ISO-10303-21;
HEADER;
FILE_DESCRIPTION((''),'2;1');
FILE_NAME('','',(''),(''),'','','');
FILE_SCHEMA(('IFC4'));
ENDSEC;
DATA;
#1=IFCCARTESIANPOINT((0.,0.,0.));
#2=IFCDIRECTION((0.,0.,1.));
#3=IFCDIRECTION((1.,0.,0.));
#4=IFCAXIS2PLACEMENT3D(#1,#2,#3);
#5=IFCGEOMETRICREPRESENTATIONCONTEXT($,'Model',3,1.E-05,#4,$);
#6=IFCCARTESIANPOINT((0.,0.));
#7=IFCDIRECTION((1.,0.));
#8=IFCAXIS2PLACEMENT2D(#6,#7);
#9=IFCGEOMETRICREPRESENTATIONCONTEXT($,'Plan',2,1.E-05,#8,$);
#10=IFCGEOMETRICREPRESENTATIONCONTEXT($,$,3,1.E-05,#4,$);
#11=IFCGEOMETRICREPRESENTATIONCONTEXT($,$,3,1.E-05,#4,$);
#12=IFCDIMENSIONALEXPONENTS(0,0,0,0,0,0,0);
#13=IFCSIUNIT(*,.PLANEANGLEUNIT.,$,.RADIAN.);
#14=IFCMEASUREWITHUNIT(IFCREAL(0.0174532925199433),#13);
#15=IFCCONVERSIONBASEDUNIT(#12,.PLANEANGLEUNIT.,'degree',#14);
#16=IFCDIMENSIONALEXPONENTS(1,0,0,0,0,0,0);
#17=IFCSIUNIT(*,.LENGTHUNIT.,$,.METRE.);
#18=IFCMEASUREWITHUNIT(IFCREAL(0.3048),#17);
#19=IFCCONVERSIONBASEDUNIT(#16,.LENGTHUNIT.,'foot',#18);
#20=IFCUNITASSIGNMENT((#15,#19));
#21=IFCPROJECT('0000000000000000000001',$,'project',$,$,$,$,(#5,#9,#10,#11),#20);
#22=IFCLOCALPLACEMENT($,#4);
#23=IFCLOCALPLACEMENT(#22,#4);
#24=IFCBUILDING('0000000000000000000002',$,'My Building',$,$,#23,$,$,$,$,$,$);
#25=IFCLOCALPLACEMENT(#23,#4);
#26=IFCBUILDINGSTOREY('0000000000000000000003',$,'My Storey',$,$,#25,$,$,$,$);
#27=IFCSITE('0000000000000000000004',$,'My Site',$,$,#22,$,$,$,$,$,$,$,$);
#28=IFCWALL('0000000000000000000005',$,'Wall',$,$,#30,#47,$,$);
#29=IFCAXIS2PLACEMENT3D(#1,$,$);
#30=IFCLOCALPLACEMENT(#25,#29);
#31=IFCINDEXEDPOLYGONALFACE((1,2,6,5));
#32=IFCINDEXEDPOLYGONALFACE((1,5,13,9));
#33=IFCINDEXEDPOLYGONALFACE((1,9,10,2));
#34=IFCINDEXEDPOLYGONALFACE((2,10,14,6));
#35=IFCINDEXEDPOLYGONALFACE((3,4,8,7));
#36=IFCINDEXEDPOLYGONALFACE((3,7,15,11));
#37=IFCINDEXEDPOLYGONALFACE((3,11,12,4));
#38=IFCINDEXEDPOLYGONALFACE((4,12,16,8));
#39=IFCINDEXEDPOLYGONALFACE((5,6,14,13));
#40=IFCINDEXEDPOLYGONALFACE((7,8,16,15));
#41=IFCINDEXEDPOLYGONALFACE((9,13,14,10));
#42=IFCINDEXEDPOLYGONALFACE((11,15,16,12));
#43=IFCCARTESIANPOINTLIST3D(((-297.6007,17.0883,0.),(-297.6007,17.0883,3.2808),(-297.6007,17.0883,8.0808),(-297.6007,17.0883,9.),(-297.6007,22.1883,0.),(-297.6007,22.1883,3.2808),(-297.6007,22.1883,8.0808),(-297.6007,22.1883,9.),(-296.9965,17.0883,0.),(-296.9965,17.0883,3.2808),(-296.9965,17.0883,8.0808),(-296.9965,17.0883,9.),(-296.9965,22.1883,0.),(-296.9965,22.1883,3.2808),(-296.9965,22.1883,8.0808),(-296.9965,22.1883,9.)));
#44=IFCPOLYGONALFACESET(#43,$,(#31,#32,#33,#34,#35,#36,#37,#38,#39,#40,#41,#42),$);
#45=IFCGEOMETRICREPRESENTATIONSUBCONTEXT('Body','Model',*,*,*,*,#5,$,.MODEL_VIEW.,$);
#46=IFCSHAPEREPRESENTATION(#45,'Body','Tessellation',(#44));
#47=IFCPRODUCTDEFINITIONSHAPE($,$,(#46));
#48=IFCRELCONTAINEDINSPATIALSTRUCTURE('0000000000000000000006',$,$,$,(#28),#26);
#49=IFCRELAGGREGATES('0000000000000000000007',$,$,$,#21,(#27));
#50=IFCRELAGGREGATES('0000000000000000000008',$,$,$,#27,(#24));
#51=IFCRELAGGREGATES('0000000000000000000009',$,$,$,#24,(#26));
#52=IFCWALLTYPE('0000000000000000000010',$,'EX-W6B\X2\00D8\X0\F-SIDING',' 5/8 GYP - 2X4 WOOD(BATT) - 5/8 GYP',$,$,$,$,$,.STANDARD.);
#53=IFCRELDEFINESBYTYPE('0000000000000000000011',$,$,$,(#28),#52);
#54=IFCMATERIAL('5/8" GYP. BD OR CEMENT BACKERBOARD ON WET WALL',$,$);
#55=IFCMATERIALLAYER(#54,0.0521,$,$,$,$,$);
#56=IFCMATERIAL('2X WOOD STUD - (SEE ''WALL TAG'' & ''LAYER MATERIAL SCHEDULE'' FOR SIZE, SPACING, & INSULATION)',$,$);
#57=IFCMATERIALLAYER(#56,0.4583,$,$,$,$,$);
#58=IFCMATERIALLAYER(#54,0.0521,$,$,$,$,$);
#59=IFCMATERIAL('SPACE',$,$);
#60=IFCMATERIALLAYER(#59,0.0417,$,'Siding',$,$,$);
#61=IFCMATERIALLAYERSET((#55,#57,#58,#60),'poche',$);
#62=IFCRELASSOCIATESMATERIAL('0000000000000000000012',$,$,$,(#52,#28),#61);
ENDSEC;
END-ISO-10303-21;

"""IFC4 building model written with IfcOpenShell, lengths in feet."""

from ifc_helpers import new_model, entity, si_unit, converted_unit, frame, origin_with_axes, origin_2d_with_axis, place, context, subcontext, project, spatial, line, indexed_curve, outline, extrude, source, transform, mapped, material, layer, layer_set, layer_usage, type_object, element, save


model = new_model("IFC4")

# Units and contexts
model_context = context("Model", 3, precision=1e-05, world=origin_with_axes())
plan_context = context("Plan", 2, precision=1e-05, world=origin_2d_with_axis())
context_of_model_1 = context(None, 3, precision=1e-05, world=origin_with_axes())
context_of_model_2 = context(None, 3, precision=1e-05, world=origin_with_axes())
body_context = subcontext(model_context, "Body", "Model", "MODEL_VIEW")
ifc_project = project(units=[converted_unit("PLANEANGLEUNIT", "degree", entity("IfcReal", 0.0174532925199433), si_unit("PLANEANGLEUNIT", "RADIAN"), dimensions=[0, 0, 0, 0, 0, 0, 0]), converted_unit("LENGTHUNIT", "foot", entity("IfcReal", 0.3048), si_unit("LENGTHUNIT", "METRE"), dimensions=[1, 0, 0, 0, 0, 0, 0])], contexts=[model_context, plan_context, context_of_model_1, context_of_model_2])

# Site, building, storey
site_placement = place(None, origin_with_axes())
site = spatial("IfcSite", under=ifc_project, at=site_placement, Name="My Site")
building_placement = place(site_placement, origin_with_axes())
building = spatial("IfcBuilding", under=site, at=building_placement, Name="My Building")
storey_placement = place(building_placement, origin_with_axes())
storey = spatial("IfcBuildingStorey", under=building, at=storey_placement, Name="My Storey")

# Shared definitions
ifc_material_1 = material(Name="5/8\" GYP. BD OR CEMENT BACKERBOARD ON WET WALL")
ifc_material_2 = material(Name="2X WOOD STUD - (SEE 'WALL TAG' & 'LAYER MATERIAL SCHEDULE' FOR SIZE, SPACING, & INSULATION)")

# Shared definitions
ifc_material_3 = material(Name="SPACE")

# Shared definitions
ifc_layer_1 = layer(ifc_material_1, 0.0521)
ifc_layer_2 = layer(ifc_material_2, 0.4583)
ifc_layer_3 = layer(ifc_material_1, 0.0521)
ifc_layer_4 = layer(ifc_material_3, 0.0417, Name="Siding")
ifc_layer_set_1 = layer_set([ifc_layer_1, ifc_layer_2, ifc_layer_3, ifc_layer_4], Name="poche")
wall_type_1 = type_object("IfcWallType", Name="EX-W6BØF-SIDING", Description=" 5/8 GYP - 2X4 WOOD(BATT) - 5/8 GYP", PredefinedType="STANDARD", material=ifc_layer_set_1)

# Wall, opening
ifc_layer_usage_1 = layer_usage(ifc_layer_set_1, "AXIS2", "POSITIVE", 0.0)
wall_1_placement = place(storey_placement, frame((-296.9965, 17.0883, 0.0), z_axis=(0.0, 0.0, 1.0), x_axis=(0.0, 1.0, 0.0)))
wall_1 = element("IfcWall", 1, at=wall_1_placement, inside=storey, type_object=wall_type_1, material=ifc_layer_usage_1, Name="Wall", context=body_context, shape_type="SweptSolid", body=[
    extrude(outline(indexed_curve([(0.0, 0.0), (0.0, 0.6042), (5.1, 0.6042), (5.1, 0.0), (0.0, 0.0)], self_intersect=False)), origin_with_axes(), (0.0, 0.0, 1.0), 9.0),
])
shared_shape_1 = source(origin_with_axes(), body_context, "Body", "SweptSolid", [
    extrude(outline(indexed_curve([(0.0, 0.0), (5.1, 0.0), (5.1, 4.8), (0.0, 4.8)], segments=[line(1, 2, 3, 4, 1)])), frame((0.0, -0.3281, 0.0), z_axis=(0.0, -1.0, 0.0), x_axis=(1.0, 0.0, 0.0)), (0.0, 0.0, -1.0), 1.2603),
])
opening_1_placement = place(wall_1_placement, frame((0.0, 0.0, 3.2808), z_axis=(0.0, 0.0, 1.0), x_axis=(1.0, 0.0, 0.0)))
element("IfcOpeningElement", 2, at=opening_1_placement, cuts=wall_1, PredefinedType="OPENING", context=body_context, shape_type="MappedRepresentation", body=[
    mapped(shared_shape_1, transform((0.0, 0.0, 0.0), x_axis=(1.0, 0.0, 0.0), y_axis=(0.0, 1.0, 0.0), z_axis=(0.0, 0.0, 1.0), scale=1.0)),
])

save(model, "model.ifc")
